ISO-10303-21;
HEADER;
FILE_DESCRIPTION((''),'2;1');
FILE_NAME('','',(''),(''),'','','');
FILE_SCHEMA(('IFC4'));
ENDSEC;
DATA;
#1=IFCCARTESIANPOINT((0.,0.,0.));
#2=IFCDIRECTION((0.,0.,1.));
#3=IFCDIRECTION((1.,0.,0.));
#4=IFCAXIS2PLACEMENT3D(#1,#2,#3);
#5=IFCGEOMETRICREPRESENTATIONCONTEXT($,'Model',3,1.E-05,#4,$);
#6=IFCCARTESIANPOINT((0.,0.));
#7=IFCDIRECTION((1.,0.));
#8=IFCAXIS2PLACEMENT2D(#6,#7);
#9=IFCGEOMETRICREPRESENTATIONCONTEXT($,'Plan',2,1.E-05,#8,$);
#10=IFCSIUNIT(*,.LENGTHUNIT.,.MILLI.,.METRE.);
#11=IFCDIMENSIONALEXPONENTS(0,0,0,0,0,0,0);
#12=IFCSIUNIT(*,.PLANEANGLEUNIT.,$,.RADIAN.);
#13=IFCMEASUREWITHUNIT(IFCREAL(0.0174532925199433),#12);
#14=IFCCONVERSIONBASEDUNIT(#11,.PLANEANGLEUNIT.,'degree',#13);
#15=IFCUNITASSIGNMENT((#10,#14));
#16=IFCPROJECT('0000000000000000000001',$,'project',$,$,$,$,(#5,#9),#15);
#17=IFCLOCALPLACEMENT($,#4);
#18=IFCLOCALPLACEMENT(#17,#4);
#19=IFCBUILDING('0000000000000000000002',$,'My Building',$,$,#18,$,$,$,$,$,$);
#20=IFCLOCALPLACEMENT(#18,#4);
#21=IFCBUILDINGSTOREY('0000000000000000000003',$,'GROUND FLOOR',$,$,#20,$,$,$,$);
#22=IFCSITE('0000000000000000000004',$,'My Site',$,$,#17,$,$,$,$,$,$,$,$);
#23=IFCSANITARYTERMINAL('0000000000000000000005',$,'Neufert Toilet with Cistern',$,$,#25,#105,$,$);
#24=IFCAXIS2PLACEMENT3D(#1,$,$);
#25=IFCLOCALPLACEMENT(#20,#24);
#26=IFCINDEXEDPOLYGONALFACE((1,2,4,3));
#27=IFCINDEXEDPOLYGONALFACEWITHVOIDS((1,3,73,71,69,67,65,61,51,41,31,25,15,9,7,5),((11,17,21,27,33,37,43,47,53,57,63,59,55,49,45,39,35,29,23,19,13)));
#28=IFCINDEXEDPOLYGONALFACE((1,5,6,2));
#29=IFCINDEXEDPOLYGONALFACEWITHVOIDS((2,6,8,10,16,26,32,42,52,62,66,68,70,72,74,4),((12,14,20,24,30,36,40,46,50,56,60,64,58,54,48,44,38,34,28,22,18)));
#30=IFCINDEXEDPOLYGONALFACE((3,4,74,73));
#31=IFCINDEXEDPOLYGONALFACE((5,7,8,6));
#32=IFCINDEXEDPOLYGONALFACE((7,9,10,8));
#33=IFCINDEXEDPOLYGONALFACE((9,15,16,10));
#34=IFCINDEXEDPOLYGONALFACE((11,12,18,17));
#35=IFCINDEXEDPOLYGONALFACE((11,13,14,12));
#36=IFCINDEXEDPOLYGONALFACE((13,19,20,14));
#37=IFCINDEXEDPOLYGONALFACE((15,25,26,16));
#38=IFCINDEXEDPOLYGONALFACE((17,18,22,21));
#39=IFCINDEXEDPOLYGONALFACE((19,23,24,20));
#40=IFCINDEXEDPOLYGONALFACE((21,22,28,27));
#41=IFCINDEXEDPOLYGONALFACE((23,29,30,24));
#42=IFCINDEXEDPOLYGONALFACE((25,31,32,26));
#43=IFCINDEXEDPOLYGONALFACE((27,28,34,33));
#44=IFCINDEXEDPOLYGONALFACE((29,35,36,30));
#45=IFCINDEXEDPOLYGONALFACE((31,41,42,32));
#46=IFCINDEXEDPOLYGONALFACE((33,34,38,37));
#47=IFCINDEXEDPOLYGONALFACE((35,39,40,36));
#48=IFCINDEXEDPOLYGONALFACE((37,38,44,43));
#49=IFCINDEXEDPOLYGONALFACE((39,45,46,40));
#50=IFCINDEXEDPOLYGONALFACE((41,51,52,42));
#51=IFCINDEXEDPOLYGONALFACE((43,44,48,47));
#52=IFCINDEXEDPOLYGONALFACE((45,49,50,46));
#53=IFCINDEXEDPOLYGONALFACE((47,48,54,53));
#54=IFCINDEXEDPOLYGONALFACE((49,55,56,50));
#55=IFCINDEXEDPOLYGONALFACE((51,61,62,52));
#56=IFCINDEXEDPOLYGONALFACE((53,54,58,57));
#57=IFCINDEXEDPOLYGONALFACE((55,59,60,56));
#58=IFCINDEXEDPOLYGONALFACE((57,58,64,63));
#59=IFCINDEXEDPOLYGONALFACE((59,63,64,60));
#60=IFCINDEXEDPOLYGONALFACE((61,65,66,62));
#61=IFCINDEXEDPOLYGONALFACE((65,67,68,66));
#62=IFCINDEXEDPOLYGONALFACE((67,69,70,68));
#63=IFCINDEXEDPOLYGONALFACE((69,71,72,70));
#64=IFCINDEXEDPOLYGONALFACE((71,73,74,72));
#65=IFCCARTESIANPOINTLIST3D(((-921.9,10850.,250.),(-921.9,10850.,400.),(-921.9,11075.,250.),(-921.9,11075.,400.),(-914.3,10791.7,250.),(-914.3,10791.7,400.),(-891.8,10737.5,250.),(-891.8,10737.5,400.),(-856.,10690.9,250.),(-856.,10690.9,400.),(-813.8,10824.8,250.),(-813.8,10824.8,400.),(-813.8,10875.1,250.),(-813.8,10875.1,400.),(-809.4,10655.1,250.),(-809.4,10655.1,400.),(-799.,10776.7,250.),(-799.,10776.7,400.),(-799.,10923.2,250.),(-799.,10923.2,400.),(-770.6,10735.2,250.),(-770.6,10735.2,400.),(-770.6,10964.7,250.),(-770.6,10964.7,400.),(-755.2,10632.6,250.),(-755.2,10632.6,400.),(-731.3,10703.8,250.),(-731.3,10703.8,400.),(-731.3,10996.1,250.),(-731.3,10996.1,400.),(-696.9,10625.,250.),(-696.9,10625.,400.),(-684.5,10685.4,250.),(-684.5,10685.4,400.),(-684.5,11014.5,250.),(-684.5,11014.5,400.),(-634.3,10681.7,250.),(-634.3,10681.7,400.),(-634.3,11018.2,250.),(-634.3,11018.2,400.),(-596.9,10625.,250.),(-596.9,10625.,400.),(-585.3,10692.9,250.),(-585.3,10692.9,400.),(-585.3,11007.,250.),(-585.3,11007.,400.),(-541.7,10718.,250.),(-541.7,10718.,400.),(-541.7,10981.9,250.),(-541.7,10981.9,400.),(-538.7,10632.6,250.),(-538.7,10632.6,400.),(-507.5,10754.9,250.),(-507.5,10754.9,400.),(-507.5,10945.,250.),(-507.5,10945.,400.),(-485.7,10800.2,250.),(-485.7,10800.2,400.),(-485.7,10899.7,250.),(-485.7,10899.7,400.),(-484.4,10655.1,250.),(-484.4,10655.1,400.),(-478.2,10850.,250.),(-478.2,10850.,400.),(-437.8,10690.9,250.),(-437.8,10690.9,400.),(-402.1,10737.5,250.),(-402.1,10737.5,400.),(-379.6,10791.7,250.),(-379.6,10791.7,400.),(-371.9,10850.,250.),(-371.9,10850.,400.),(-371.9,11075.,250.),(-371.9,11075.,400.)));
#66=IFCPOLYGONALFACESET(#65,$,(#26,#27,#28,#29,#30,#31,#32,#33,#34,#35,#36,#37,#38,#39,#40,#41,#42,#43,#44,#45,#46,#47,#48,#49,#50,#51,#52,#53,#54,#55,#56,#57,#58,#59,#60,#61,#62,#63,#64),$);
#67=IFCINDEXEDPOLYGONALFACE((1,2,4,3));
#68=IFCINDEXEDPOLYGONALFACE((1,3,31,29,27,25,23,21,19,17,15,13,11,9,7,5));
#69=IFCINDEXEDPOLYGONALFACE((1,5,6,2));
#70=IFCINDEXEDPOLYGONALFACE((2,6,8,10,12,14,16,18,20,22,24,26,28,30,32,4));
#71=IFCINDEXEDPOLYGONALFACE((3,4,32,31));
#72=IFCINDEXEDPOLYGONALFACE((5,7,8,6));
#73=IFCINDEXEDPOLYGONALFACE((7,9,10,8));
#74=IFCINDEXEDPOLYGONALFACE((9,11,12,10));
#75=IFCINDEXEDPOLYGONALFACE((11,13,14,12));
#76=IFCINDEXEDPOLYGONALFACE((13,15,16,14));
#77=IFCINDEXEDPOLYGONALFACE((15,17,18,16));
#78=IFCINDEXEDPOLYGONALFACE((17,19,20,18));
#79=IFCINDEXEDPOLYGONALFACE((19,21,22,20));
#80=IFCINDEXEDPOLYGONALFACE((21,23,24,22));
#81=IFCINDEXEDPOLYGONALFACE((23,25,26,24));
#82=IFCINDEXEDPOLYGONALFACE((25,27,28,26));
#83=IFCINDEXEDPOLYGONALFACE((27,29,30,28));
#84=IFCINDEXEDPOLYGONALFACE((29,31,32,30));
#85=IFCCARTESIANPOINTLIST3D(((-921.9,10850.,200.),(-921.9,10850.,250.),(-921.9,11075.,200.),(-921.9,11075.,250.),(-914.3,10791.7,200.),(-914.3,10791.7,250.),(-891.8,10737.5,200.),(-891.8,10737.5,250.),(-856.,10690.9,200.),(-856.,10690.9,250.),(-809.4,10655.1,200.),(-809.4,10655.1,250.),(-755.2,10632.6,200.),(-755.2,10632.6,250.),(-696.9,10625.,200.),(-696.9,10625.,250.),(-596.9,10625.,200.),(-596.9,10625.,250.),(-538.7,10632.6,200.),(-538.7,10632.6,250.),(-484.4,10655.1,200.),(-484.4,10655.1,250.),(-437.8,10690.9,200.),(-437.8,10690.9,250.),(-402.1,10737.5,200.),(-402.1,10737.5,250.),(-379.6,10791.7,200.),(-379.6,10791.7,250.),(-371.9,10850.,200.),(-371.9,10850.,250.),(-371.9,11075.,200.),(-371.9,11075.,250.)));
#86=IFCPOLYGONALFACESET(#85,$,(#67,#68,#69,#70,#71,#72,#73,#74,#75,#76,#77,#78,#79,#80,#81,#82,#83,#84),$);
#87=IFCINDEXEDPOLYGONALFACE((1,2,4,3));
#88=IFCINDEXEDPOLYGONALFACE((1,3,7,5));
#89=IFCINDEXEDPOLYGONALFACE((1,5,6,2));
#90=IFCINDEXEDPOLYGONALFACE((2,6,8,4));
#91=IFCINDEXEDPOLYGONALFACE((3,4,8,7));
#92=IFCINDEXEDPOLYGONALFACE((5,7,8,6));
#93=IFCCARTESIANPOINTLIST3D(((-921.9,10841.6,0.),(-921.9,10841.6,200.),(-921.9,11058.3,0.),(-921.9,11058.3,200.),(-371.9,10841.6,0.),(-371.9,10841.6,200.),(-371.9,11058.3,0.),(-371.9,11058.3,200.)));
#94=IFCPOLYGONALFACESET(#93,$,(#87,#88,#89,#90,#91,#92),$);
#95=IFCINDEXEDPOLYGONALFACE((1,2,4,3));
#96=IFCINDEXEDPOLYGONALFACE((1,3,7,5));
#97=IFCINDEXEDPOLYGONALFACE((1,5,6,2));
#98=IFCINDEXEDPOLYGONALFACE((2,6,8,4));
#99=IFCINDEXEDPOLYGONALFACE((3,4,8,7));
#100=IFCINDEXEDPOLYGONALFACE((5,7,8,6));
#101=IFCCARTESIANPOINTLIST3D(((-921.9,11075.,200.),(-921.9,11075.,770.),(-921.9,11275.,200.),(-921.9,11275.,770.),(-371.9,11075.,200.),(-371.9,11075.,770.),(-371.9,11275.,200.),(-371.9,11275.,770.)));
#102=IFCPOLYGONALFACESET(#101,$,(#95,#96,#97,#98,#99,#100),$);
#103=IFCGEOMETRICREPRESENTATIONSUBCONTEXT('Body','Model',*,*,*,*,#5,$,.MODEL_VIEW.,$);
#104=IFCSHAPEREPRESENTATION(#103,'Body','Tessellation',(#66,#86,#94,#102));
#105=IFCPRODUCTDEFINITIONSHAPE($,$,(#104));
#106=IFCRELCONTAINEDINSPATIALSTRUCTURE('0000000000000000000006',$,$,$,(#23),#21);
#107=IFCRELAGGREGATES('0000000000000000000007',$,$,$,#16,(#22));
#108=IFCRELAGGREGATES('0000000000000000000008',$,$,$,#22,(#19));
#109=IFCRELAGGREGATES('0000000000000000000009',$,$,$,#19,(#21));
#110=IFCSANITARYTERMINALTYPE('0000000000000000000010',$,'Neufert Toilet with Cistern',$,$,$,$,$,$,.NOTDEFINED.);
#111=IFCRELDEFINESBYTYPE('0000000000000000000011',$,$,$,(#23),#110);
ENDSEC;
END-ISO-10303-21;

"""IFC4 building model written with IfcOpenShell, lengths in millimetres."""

from ifc_helpers import new_model, entity, si_unit, converted_unit, frame, frame_2d, origin_with_axes, origin_2d_with_axis, place, context, subcontext, project, spatial, line, arc, indexed_curve, circle_curve, outline, extrude, shape, source, transform, mapped, type_object, type_shapes, element, save


model = new_model("IFC4")

# Units and contexts
model_context = context("Model", 3, precision=1e-05, world=origin_with_axes())
plan_context = context("Plan", 2, precision=1e-05, world=origin_2d_with_axis())
body_context_1 = subcontext(model_context, "Body", "Model", "MODEL_VIEW")
body_context_2 = subcontext(plan_context, "Body", "Plan", "PLAN_VIEW")
ifc_project = project(units=[si_unit("LENGTHUNIT", "METRE", prefix="MILLI"), converted_unit("PLANEANGLEUNIT", "degree", entity("IfcReal", 0.0174532925199433), si_unit("PLANEANGLEUNIT", "RADIAN"), dimensions=[0, 0, 0, 0, 0, 0, 0])], contexts=[model_context, plan_context])

# Site, building, storey
site_placement = place(None, origin_with_axes())
site = spatial("IfcSite", under=ifc_project, at=site_placement, Name="My Site")
building_placement = place(site_placement, origin_with_axes())
building = spatial("IfcBuilding", under=site, at=building_placement, Name="My Building")
storey_placement = place(building_placement, origin_with_axes())
storey = spatial("IfcBuildingStorey", under=building, at=storey_placement, Name="GROUND FLOOR")

# Sanitary terminal
sanitary_terminal_type_1 = type_object("IfcSanitaryTerminalType", Name="Neufert Toilet with Cistern", PredefinedType="NOTDEFINED")
shared_shape_1 = source(origin_with_axes(), body_context_1, "Body", "SweptSolid", [
    extrude(outline(indexed_curve([(-275.0, -200.0), (275.0, -200.0), (275.0, -425.0), (209.1, -584.1), (50.0, -650.0), (-50.0, -650.0), (-209.1, -584.1), (-275.0, -425.0)], segments=[line(1, 2), line(2, 3), arc(3, 4, 5), line(5, 6), arc(6, 7, 8), line(8, 1)]), holes=[circle_curve(frame_2d((0.0, -425.0)), 168.8)]), frame((0.0, 0.0, 250.0), z_axis=(0.0, 0.0, 1.0), x_axis=(1.0, 0.0, 0.0)), (0.0, 0.0, 1.0), 150.0),
    extrude(outline(indexed_curve([(-275.0, -200.0), (275.0, -200.0), (275.0, -425.0), (209.1, -584.1), (50.0, -650.0), (-50.0, -650.0), (-209.1, -584.1), (-275.0, -425.0)], segments=[line(1, 2), line(2, 3), arc(3, 4, 5), line(5, 6), arc(6, 7, 8), line(8, 1)])), frame((0.0, 0.0, 200.0), z_axis=(0.0, 0.0, 1.0), x_axis=(1.0, 0.0, 0.0)), (0.0, 0.0, 1.0), 50.0),
    extrude(outline(indexed_curve([(-275.0, -216.7), (275.0, -216.7), (275.0, -433.3), (-275.0, -433.3)], segments=[line(1, 2), line(2, 3), line(3, 4), line(4, 1)])), origin_with_axes(), (0.0, 0.0, 1.0), 200.0),
    extrude(outline(indexed_curve([(-275.0, 0.0), (275.0, 0.0), (275.0, -200.0), (-275.0, -200.0)], segments=[line(1, 2), line(2, 3), line(3, 4), line(4, 1)])), frame((0.0, 0.0, 200.0), z_axis=(0.0, 0.0, 1.0), x_axis=(1.0, 0.0, 0.0)), (0.0, 0.0, 1.0), 570.0),
])
shared_shape_2 = source(origin_with_axes(), body_context_2, "Body", "Curve2D", [
    entity("IfcIndexedPolyCurve", entity("IfcCartesianPointList2D", [[-275.0, 0.0], [275.0, 0.0], [275.0, -200.0], [-275.0, -200.0]]), [entity("IfcLineIndex", [1, 2]), entity("IfcLineIndex", [2, 3]), entity("IfcLineIndex", [3, 4]), entity("IfcLineIndex", [4, 1])]),
    entity("IfcIndexedPolyCurve", entity("IfcCartesianPointList2D", [[165.0, -200.0], [192.5, -335.0]]), [entity("IfcLineIndex", [1, 2])]),
    entity("IfcTrimmedCurve", entity("IfcEllipse", entity("IfcAxis2Placement2D", entity("IfcCartesianPoint", [0.0, -335.0]), entity("IfcDirection", [1.0, 0.0])), 192.5, 315.0), [entity("IfcCartesianPoint", [-192.5, -335.0])], [entity("IfcCartesianPoint", [192.5, -335.0])], True, "CARTESIAN"),
    entity("IfcIndexedPolyCurve", entity("IfcCartesianPointList2D", [[-165.0, -200.0], [-192.5, -335.0]]), [entity("IfcLineIndex", [1, 2])]),
    entity("IfcEllipse", entity("IfcAxis2Placement2D", entity("IfcCartesianPoint", [0.0, -452.0]), entity("IfcDirection", [1.0, 0.0])), 131.2, 157.5),
    entity("IfcIndexedPolyCurve", entity("IfcCartesianPointList2D", [[-34.4, -452.0], [-34.4, -429.5], [34.4, -429.5], [34.4, -452.0]]), [entity("IfcLineIndex", [1, 2]), entity("IfcLineIndex", [2, 3]), entity("IfcLineIndex", [3, 4])]),
    entity("IfcTrimmedCurve", entity("IfcEllipse", entity("IfcAxis2Placement2D", entity("IfcCartesianPoint", [0.0, -452.0]), entity("IfcDirection", [1.0, 0.0])), 34.4, 22.5), [entity("IfcCartesianPoint", [-34.4, -452.0])], [entity("IfcCartesianPoint", [34.4, -452.0])], True, "CARTESIAN"),
])
type_shapes(sanitary_terminal_type_1, [shared_shape_1, shared_shape_2])
sanitary_terminal_1_placement = place(storey_placement, frame((-646.9, 11275.0, 0.0), z_axis=(0.0, 0.0, 1.0), x_axis=(1.0, 0.0, 0.0)))
element("IfcSanitaryTerminal", 1, at=sanitary_terminal_1_placement, inside=storey, type_object=sanitary_terminal_type_1, Name="Neufert Toilet with Cistern", shapes=[
    shape(body_context_1, "Body", "MappedRepresentation", [mapped(shared_shape_1, transform((0.0, 0.0, 0.0), x_axis=(1.0, 0.0, 0.0), y_axis=(0.0, 1.0, 0.0), z_axis=(0.0, 0.0, 1.0), scale=1.0))]),
    shape(body_context_2, "Body", "MappedRepresentation", [mapped(shared_shape_2, transform((0.0, 0.0, 0.0), x_axis=(1.0, 0.0, 0.0), y_axis=(0.0, 1.0, 0.0), z_axis=(0.0, 0.0, 1.0), scale=1.0))]),
])

save(model, "model.ifc")
